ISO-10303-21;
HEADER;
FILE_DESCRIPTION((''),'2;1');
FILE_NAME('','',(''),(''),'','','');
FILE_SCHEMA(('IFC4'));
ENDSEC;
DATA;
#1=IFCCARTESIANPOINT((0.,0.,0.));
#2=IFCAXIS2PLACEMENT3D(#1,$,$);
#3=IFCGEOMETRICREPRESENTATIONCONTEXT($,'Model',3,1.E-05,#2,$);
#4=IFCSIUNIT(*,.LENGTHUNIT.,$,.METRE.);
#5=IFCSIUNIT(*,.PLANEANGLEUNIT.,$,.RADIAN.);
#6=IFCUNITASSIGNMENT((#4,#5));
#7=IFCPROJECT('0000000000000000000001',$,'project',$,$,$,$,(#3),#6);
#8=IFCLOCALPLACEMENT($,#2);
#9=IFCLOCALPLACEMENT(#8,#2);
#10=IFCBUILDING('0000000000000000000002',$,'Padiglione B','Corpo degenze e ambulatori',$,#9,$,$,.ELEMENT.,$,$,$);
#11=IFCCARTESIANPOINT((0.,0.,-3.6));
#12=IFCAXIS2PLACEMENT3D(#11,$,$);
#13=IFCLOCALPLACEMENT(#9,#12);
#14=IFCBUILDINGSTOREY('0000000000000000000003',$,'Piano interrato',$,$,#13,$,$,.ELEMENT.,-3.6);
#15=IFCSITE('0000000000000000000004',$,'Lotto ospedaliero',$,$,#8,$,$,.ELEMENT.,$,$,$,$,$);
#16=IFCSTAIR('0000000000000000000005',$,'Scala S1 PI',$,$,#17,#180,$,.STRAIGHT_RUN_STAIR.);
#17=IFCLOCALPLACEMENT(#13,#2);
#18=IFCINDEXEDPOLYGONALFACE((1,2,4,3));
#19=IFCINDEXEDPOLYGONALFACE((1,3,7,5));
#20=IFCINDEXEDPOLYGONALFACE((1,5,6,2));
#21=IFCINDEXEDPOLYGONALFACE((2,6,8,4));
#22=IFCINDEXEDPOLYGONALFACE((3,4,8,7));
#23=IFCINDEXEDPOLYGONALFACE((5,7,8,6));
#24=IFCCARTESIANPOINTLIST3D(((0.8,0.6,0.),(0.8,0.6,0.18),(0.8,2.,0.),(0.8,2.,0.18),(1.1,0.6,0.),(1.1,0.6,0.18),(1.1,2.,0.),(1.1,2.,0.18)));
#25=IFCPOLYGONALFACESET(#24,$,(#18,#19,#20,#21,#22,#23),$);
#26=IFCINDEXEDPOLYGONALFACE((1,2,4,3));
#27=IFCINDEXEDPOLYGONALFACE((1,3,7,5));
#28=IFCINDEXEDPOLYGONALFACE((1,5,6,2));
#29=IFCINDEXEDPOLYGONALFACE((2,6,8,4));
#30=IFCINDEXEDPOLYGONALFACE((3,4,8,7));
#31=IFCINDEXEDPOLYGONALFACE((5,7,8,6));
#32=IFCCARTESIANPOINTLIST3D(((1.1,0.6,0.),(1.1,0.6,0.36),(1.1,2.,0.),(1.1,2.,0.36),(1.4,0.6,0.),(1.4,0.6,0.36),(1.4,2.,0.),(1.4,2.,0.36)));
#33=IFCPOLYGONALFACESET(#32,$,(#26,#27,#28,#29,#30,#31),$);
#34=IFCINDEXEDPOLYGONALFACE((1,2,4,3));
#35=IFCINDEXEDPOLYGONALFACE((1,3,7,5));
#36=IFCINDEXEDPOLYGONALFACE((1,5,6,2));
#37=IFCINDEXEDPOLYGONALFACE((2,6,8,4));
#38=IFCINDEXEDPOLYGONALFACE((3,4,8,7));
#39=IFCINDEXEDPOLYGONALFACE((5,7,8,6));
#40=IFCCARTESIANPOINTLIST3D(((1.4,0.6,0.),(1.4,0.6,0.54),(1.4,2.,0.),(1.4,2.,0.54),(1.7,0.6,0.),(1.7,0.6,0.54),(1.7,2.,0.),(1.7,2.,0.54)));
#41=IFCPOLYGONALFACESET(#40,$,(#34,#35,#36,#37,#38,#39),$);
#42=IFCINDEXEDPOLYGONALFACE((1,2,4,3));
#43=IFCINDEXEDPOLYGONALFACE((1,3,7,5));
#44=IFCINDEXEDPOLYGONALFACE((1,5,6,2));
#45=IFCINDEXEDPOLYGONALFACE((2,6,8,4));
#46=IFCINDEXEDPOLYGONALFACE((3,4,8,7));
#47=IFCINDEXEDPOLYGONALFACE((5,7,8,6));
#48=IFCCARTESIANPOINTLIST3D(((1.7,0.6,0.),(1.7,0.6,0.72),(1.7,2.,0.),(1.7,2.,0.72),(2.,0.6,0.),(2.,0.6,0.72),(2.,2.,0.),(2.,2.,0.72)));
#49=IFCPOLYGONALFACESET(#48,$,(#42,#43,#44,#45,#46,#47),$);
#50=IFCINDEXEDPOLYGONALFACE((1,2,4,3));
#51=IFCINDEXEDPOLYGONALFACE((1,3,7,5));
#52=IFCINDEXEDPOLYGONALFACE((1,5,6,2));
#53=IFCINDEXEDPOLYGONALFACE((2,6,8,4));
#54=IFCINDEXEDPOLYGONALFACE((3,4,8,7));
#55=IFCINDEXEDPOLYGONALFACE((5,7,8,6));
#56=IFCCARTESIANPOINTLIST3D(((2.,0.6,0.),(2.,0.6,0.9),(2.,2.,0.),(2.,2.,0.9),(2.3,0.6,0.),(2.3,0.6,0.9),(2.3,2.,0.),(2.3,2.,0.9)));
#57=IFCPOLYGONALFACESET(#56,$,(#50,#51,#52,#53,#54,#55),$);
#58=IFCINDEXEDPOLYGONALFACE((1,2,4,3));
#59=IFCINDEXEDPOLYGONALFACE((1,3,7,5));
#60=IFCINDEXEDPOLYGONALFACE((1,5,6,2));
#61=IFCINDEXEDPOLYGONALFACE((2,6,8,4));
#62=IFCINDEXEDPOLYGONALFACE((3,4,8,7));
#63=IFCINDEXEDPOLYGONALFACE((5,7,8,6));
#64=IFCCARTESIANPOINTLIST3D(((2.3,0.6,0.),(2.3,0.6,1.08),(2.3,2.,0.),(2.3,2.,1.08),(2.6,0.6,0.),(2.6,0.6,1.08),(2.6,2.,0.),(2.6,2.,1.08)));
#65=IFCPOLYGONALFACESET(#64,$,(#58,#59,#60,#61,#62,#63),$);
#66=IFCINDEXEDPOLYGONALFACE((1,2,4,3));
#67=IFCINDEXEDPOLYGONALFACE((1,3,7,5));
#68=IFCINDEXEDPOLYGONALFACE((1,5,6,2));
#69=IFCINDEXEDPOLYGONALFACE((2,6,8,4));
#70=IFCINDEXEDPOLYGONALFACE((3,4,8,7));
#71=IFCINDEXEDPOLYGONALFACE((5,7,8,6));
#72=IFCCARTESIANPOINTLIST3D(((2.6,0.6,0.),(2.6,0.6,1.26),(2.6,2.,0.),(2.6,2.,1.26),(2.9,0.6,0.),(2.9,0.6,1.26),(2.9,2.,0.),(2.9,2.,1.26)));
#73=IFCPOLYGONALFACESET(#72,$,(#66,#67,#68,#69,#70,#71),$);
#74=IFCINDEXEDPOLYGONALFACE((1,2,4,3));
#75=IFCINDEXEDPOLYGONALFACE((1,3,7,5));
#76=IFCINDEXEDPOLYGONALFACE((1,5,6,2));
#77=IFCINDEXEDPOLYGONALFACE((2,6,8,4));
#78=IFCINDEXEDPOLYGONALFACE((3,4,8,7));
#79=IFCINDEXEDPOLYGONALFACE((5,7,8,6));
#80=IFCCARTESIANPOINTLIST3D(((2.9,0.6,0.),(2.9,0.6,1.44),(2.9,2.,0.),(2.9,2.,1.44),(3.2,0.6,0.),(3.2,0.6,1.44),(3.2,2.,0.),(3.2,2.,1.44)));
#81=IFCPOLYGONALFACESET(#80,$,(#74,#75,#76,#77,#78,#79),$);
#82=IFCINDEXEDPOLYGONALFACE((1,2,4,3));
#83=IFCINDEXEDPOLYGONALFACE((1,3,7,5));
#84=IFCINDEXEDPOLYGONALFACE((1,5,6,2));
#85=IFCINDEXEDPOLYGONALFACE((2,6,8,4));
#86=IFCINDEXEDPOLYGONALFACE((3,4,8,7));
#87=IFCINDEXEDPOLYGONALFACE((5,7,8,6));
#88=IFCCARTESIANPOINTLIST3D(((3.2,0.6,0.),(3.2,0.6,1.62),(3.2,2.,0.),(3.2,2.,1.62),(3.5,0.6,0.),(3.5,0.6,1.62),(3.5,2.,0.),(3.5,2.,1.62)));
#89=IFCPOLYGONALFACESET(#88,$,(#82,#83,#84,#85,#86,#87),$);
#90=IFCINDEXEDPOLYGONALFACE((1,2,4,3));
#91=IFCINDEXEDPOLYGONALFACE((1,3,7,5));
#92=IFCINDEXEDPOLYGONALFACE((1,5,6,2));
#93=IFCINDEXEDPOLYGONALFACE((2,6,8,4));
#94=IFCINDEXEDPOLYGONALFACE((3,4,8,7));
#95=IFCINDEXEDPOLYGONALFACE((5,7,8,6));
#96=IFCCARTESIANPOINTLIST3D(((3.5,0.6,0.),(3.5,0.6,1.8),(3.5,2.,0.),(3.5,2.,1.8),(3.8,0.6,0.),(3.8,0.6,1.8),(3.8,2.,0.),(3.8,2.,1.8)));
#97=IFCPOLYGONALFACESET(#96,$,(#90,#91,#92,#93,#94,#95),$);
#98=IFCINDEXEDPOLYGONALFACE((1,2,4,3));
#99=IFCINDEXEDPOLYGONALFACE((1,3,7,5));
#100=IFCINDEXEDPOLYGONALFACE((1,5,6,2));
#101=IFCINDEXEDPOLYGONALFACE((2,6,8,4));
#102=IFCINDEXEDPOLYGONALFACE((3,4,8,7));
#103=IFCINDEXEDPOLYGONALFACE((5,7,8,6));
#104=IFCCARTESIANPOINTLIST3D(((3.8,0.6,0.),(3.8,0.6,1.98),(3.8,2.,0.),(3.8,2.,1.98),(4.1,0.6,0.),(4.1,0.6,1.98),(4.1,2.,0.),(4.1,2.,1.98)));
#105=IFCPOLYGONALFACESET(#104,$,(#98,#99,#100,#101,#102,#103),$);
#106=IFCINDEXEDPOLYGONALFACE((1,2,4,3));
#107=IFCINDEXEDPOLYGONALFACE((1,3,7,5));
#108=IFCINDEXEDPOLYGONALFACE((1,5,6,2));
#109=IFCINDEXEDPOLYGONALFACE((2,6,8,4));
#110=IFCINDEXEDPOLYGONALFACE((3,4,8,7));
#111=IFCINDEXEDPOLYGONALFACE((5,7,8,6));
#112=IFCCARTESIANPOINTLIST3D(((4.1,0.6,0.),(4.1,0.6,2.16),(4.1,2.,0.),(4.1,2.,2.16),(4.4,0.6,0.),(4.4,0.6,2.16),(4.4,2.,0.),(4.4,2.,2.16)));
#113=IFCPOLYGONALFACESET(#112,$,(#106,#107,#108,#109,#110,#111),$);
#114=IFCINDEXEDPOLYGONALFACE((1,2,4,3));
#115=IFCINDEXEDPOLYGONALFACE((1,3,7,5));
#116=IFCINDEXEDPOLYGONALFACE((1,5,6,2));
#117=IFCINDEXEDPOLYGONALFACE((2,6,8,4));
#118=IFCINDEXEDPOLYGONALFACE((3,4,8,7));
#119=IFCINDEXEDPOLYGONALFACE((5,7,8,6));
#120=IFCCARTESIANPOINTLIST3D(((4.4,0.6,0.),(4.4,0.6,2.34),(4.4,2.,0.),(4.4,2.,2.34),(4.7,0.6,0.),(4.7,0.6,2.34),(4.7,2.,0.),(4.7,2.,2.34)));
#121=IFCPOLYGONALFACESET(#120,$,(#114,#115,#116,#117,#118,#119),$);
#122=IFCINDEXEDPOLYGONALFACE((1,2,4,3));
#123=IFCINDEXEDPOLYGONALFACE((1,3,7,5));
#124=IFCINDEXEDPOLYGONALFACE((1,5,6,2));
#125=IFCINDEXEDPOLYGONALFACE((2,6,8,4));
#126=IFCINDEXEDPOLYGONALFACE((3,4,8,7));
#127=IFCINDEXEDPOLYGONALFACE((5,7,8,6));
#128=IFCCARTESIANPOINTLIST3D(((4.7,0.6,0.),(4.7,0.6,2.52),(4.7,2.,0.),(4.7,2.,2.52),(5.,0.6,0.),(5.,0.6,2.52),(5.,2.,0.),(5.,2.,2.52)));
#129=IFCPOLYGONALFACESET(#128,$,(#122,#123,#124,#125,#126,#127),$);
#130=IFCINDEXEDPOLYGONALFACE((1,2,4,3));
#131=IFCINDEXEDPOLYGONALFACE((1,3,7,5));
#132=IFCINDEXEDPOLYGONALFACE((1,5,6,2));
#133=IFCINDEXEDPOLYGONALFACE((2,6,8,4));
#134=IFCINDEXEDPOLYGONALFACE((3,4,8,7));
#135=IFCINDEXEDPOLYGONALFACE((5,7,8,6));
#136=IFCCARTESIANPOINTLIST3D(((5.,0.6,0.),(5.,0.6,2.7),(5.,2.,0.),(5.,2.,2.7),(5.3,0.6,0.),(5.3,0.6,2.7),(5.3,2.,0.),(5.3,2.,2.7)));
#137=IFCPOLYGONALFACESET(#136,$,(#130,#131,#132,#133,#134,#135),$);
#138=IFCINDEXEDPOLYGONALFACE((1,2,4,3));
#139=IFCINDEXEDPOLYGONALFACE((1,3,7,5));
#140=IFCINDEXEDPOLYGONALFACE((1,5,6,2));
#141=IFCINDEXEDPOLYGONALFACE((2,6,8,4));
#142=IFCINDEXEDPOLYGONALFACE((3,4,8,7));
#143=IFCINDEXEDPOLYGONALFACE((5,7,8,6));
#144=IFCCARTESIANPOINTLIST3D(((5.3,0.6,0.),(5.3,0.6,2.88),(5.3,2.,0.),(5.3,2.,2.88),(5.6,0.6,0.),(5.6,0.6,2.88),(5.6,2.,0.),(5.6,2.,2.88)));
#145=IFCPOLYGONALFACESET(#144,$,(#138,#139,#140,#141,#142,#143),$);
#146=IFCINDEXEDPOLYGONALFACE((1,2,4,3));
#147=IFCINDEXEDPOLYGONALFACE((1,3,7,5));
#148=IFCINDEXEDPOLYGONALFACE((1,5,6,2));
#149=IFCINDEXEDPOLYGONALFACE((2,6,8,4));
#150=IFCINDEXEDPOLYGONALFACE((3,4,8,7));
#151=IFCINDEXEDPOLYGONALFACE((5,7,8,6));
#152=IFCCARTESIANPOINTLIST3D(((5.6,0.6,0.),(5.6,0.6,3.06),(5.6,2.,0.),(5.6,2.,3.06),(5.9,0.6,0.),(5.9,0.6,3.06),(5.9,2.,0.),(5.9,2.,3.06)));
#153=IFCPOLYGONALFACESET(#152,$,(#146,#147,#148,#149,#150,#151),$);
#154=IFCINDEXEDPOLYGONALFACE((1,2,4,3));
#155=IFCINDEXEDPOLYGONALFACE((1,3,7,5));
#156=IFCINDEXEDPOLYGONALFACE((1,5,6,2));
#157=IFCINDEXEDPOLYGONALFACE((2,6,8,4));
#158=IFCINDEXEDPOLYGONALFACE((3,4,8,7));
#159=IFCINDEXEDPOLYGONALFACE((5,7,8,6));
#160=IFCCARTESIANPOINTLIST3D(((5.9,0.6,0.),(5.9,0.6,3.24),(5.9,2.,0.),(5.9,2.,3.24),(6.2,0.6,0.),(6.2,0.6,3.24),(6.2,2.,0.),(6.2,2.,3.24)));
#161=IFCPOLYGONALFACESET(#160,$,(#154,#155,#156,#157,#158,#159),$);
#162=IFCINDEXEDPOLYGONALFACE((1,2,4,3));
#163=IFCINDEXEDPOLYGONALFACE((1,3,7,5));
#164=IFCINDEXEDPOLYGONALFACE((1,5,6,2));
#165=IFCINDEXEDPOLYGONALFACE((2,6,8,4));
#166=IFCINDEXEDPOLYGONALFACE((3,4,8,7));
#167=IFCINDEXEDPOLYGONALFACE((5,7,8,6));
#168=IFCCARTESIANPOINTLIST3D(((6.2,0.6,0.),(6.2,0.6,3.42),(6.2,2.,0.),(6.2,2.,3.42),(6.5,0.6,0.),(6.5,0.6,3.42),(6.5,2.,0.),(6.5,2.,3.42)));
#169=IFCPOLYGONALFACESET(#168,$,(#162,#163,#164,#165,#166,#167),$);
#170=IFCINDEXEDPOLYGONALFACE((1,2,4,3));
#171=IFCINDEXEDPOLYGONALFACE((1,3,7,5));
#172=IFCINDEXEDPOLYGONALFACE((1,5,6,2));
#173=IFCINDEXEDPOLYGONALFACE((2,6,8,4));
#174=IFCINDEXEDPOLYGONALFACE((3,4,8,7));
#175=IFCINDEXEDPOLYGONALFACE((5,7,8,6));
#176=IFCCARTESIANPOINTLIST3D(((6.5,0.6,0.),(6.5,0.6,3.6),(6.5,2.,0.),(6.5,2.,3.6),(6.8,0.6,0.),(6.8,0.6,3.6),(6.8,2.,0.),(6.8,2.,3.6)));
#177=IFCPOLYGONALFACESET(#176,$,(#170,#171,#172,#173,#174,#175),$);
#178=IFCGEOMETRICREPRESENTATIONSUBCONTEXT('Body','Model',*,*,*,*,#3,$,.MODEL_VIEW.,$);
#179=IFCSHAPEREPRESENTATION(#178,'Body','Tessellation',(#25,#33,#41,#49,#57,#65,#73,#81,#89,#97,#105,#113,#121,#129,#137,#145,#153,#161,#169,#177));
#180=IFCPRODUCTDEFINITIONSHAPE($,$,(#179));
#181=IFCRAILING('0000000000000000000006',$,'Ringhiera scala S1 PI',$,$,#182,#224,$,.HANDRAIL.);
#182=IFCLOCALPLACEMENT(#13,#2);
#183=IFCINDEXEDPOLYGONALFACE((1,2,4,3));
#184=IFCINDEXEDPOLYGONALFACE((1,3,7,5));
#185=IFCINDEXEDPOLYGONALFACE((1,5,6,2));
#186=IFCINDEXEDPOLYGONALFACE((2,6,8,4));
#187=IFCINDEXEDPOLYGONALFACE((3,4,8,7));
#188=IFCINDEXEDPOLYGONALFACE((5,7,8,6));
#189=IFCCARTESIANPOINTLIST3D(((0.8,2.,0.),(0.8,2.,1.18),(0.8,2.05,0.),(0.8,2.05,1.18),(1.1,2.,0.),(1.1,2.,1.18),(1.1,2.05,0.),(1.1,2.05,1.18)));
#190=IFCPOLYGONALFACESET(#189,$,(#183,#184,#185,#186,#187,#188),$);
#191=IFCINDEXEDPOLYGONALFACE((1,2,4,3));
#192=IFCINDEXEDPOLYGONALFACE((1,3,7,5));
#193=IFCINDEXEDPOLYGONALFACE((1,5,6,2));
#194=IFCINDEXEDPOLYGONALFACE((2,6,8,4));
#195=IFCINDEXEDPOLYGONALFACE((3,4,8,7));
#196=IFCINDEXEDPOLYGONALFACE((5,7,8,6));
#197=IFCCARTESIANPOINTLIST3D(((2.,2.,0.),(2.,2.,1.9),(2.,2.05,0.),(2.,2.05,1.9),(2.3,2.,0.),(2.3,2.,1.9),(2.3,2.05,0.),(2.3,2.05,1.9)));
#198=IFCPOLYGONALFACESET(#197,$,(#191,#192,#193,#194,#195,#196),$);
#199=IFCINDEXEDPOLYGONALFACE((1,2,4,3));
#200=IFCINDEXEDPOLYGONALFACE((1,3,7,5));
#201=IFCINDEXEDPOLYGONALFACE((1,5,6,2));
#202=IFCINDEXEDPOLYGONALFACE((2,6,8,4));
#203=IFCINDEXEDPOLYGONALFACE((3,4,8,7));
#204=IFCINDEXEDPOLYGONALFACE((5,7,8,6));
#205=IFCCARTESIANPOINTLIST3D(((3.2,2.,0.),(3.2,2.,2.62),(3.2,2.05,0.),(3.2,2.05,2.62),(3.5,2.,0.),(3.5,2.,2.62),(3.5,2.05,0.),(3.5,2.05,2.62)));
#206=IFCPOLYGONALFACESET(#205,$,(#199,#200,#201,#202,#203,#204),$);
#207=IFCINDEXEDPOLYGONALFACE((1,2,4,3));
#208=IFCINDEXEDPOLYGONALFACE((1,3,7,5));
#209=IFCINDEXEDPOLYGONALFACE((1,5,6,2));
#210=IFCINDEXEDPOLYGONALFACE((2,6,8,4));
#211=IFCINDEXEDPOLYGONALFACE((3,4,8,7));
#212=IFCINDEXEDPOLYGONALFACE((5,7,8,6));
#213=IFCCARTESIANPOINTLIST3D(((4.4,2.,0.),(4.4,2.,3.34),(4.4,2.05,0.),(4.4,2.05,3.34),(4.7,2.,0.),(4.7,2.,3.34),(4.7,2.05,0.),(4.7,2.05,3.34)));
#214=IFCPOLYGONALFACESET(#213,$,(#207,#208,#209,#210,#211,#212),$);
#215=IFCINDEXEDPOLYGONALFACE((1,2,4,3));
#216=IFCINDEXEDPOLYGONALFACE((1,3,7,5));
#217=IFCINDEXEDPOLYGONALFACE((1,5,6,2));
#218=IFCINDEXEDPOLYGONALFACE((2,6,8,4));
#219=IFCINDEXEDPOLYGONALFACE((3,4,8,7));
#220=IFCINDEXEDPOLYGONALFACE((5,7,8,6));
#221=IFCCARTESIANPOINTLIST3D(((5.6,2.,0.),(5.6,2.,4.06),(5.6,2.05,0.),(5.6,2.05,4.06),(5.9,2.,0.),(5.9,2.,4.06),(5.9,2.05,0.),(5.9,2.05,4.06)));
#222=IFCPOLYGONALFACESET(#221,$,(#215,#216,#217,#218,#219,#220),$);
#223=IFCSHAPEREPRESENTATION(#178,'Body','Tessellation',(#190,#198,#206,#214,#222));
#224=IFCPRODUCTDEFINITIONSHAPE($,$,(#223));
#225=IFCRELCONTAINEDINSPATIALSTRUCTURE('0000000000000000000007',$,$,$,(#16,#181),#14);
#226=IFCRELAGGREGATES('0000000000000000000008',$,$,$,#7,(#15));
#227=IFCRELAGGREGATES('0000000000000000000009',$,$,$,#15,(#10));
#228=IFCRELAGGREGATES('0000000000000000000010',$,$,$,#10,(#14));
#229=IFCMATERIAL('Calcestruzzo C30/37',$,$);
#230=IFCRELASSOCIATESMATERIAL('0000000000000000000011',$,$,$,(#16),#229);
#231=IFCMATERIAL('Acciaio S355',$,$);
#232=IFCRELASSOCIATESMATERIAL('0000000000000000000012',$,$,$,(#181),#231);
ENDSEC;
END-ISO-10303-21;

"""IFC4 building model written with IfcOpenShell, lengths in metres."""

from ifc_helpers import new_model, si_unit, frame, frame_2d, origin, place, context, subcontext, project, spatial, rectangle, extrude, material, element, save


model = new_model("IFC4")

# Units and contexts
model_context = context("Model", 3, precision=1e-05, world=origin())
body_context = subcontext(model_context, "Body", "Model", "MODEL_VIEW")
ifc_project = project(units=[si_unit("LENGTHUNIT", "METRE"), si_unit("PLANEANGLEUNIT", "RADIAN")], contexts=[model_context])

# Site, building, storey
site_placement = place(None, origin())
site = spatial("IfcSite", under=ifc_project, at=site_placement, Name="Lotto ospedaliero", CompositionType="ELEMENT")
building_placement = place(site_placement, origin())
building = spatial("IfcBuilding", under=site, at=building_placement, Name="Padiglione B", Description="Corpo degenze e ambulatori", CompositionType="ELEMENT")
storey_placement = place(building_placement, frame((0.0, 0.0, -3.6)))
storey = spatial("IfcBuildingStorey", under=building, at=storey_placement, Name="Piano interrato", CompositionType="ELEMENT", Elevation=-3.6)

# Shared definitions
ifc_material_1 = material(Name="Calcestruzzo C30/37")

# Stair
stair_placement = place(storey_placement, frame((0.8, 0.6, 0.0)))
element("IfcStair", 1, at=stair_placement, inside=storey, material=ifc_material_1, Name="Scala S1 PI", PredefinedType="STRAIGHT_RUN_STAIR", context=body_context, shape_type="SweptSolid", body=[
    extrude(rectangle(XDim=0.3, YDim=1.4, at=frame_2d((0.15, 0.7))), origin(), (0.0, 0.0, 1.0), 0.18),
    extrude(rectangle(XDim=0.3, YDim=1.4, at=frame_2d((0.15, 0.7))), frame((0.3, 0.0, 0.0)), (0.0, 0.0, 1.0), 0.36),
    extrude(rectangle(XDim=0.3, YDim=1.4, at=frame_2d((0.15, 0.7))), frame((0.6, 0.0, 0.0)), (0.0, 0.0, 1.0), 0.54),
    extrude(rectangle(XDim=0.3, YDim=1.4, at=frame_2d((0.15, 0.7))), frame((0.9, 0.0, 0.0)), (0.0, 0.0, 1.0), 0.72),
    extrude(rectangle(XDim=0.3, YDim=1.4, at=frame_2d((0.15, 0.7))), frame((1.2, 0.0, 0.0)), (0.0, 0.0, 1.0), 0.9),
    extrude(rectangle(XDim=0.3, YDim=1.4, at=frame_2d((0.15, 0.7))), frame((1.5, 0.0, 0.0)), (0.0, 0.0, 1.0), 1.08),
    extrude(rectangle(XDim=0.3, YDim=1.4, at=frame_2d((0.15, 0.7))), frame((1.8, 0.0, 0.0)), (0.0, 0.0, 1.0), 1.26),
    extrude(rectangle(XDim=0.3, YDim=1.4, at=frame_2d((0.15, 0.7))), frame((2.1, 0.0, 0.0)), (0.0, 0.0, 1.0), 1.44),
    extrude(rectangle(XDim=0.3, YDim=1.4, at=frame_2d((0.15, 0.7))), frame((2.4, 0.0, 0.0)), (0.0, 0.0, 1.0), 1.62),
    extrude(rectangle(XDim=0.3, YDim=1.4, at=frame_2d((0.15, 0.7))), frame((2.7, 0.0, 0.0)), (0.0, 0.0, 1.0), 1.8),
    extrude(rectangle(XDim=0.3, YDim=1.4, at=frame_2d((0.15, 0.7))), frame((3.0, 0.0, 0.0)), (0.0, 0.0, 1.0), 1.98),
    extrude(rectangle(XDim=0.3, YDim=1.4, at=frame_2d((0.15, 0.7))), frame((3.3, 0.0, 0.0)), (0.0, 0.0, 1.0), 2.16),
    extrude(rectangle(XDim=0.3, YDim=1.4, at=frame_2d((0.15, 0.7))), frame((3.6, 0.0, 0.0)), (0.0, 0.0, 1.0), 2.34),
    extrude(rectangle(XDim=0.3, YDim=1.4, at=frame_2d((0.15, 0.7))), frame((3.9, 0.0, 0.0)), (0.0, 0.0, 1.0), 2.52),
    extrude(rectangle(XDim=0.3, YDim=1.4, at=frame_2d((0.15, 0.7))), frame((4.2, 0.0, 0.0)), (0.0, 0.0, 1.0), 2.7),
    extrude(rectangle(XDim=0.3, YDim=1.4, at=frame_2d((0.15, 0.7))), frame((4.5, 0.0, 0.0)), (0.0, 0.0, 1.0), 2.88),
    extrude(rectangle(XDim=0.3, YDim=1.4, at=frame_2d((0.15, 0.7))), frame((4.8, 0.0, 0.0)), (0.0, 0.0, 1.0), 3.06),
    extrude(rectangle(XDim=0.3, YDim=1.4, at=frame_2d((0.15, 0.7))), frame((5.1, 0.0, 0.0)), (0.0, 0.0, 1.0), 3.24),
    extrude(rectangle(XDim=0.3, YDim=1.4, at=frame_2d((0.15, 0.7))), frame((5.4, 0.0, 0.0)), (0.0, 0.0, 1.0), 3.42),
    extrude(rectangle(XDim=0.3, YDim=1.4, at=frame_2d((0.15, 0.7))), frame((5.7, 0.0, 0.0)), (0.0, 0.0, 1.0), 3.6),
])

# Railing
ifc_material_2 = material(Name="Acciaio S355")
railing_placement = place(storey_placement, frame((0.8, 2.0, 0.0)))
element("IfcRailing", 2, at=railing_placement, inside=storey, material=ifc_material_2, Name="Ringhiera scala S1 PI", PredefinedType="HANDRAIL", context=body_context, shape_type="SweptSolid", body=[
    extrude(rectangle(XDim=0.3, YDim=0.05, at=frame_2d((0.15, 0.025))), origin(), (0.0, 0.0, 1.0), 1.18),
    extrude(rectangle(XDim=0.3, YDim=0.05, at=frame_2d((0.15, 0.025))), frame((1.2, 0.0, 0.0)), (0.0, 0.0, 1.0), 1.9),
    extrude(rectangle(XDim=0.3, YDim=0.05, at=frame_2d((0.15, 0.025))), frame((2.4, 0.0, 0.0)), (0.0, 0.0, 1.0), 2.62),
    extrude(rectangle(XDim=0.3, YDim=0.05, at=frame_2d((0.15, 0.025))), frame((3.6, 0.0, 0.0)), (0.0, 0.0, 1.0), 3.34),
    extrude(rectangle(XDim=0.3, YDim=0.05, at=frame_2d((0.15, 0.025))), frame((4.8, 0.0, 0.0)), (0.0, 0.0, 1.0), 4.06),
])

save(model, "model.ifc")
